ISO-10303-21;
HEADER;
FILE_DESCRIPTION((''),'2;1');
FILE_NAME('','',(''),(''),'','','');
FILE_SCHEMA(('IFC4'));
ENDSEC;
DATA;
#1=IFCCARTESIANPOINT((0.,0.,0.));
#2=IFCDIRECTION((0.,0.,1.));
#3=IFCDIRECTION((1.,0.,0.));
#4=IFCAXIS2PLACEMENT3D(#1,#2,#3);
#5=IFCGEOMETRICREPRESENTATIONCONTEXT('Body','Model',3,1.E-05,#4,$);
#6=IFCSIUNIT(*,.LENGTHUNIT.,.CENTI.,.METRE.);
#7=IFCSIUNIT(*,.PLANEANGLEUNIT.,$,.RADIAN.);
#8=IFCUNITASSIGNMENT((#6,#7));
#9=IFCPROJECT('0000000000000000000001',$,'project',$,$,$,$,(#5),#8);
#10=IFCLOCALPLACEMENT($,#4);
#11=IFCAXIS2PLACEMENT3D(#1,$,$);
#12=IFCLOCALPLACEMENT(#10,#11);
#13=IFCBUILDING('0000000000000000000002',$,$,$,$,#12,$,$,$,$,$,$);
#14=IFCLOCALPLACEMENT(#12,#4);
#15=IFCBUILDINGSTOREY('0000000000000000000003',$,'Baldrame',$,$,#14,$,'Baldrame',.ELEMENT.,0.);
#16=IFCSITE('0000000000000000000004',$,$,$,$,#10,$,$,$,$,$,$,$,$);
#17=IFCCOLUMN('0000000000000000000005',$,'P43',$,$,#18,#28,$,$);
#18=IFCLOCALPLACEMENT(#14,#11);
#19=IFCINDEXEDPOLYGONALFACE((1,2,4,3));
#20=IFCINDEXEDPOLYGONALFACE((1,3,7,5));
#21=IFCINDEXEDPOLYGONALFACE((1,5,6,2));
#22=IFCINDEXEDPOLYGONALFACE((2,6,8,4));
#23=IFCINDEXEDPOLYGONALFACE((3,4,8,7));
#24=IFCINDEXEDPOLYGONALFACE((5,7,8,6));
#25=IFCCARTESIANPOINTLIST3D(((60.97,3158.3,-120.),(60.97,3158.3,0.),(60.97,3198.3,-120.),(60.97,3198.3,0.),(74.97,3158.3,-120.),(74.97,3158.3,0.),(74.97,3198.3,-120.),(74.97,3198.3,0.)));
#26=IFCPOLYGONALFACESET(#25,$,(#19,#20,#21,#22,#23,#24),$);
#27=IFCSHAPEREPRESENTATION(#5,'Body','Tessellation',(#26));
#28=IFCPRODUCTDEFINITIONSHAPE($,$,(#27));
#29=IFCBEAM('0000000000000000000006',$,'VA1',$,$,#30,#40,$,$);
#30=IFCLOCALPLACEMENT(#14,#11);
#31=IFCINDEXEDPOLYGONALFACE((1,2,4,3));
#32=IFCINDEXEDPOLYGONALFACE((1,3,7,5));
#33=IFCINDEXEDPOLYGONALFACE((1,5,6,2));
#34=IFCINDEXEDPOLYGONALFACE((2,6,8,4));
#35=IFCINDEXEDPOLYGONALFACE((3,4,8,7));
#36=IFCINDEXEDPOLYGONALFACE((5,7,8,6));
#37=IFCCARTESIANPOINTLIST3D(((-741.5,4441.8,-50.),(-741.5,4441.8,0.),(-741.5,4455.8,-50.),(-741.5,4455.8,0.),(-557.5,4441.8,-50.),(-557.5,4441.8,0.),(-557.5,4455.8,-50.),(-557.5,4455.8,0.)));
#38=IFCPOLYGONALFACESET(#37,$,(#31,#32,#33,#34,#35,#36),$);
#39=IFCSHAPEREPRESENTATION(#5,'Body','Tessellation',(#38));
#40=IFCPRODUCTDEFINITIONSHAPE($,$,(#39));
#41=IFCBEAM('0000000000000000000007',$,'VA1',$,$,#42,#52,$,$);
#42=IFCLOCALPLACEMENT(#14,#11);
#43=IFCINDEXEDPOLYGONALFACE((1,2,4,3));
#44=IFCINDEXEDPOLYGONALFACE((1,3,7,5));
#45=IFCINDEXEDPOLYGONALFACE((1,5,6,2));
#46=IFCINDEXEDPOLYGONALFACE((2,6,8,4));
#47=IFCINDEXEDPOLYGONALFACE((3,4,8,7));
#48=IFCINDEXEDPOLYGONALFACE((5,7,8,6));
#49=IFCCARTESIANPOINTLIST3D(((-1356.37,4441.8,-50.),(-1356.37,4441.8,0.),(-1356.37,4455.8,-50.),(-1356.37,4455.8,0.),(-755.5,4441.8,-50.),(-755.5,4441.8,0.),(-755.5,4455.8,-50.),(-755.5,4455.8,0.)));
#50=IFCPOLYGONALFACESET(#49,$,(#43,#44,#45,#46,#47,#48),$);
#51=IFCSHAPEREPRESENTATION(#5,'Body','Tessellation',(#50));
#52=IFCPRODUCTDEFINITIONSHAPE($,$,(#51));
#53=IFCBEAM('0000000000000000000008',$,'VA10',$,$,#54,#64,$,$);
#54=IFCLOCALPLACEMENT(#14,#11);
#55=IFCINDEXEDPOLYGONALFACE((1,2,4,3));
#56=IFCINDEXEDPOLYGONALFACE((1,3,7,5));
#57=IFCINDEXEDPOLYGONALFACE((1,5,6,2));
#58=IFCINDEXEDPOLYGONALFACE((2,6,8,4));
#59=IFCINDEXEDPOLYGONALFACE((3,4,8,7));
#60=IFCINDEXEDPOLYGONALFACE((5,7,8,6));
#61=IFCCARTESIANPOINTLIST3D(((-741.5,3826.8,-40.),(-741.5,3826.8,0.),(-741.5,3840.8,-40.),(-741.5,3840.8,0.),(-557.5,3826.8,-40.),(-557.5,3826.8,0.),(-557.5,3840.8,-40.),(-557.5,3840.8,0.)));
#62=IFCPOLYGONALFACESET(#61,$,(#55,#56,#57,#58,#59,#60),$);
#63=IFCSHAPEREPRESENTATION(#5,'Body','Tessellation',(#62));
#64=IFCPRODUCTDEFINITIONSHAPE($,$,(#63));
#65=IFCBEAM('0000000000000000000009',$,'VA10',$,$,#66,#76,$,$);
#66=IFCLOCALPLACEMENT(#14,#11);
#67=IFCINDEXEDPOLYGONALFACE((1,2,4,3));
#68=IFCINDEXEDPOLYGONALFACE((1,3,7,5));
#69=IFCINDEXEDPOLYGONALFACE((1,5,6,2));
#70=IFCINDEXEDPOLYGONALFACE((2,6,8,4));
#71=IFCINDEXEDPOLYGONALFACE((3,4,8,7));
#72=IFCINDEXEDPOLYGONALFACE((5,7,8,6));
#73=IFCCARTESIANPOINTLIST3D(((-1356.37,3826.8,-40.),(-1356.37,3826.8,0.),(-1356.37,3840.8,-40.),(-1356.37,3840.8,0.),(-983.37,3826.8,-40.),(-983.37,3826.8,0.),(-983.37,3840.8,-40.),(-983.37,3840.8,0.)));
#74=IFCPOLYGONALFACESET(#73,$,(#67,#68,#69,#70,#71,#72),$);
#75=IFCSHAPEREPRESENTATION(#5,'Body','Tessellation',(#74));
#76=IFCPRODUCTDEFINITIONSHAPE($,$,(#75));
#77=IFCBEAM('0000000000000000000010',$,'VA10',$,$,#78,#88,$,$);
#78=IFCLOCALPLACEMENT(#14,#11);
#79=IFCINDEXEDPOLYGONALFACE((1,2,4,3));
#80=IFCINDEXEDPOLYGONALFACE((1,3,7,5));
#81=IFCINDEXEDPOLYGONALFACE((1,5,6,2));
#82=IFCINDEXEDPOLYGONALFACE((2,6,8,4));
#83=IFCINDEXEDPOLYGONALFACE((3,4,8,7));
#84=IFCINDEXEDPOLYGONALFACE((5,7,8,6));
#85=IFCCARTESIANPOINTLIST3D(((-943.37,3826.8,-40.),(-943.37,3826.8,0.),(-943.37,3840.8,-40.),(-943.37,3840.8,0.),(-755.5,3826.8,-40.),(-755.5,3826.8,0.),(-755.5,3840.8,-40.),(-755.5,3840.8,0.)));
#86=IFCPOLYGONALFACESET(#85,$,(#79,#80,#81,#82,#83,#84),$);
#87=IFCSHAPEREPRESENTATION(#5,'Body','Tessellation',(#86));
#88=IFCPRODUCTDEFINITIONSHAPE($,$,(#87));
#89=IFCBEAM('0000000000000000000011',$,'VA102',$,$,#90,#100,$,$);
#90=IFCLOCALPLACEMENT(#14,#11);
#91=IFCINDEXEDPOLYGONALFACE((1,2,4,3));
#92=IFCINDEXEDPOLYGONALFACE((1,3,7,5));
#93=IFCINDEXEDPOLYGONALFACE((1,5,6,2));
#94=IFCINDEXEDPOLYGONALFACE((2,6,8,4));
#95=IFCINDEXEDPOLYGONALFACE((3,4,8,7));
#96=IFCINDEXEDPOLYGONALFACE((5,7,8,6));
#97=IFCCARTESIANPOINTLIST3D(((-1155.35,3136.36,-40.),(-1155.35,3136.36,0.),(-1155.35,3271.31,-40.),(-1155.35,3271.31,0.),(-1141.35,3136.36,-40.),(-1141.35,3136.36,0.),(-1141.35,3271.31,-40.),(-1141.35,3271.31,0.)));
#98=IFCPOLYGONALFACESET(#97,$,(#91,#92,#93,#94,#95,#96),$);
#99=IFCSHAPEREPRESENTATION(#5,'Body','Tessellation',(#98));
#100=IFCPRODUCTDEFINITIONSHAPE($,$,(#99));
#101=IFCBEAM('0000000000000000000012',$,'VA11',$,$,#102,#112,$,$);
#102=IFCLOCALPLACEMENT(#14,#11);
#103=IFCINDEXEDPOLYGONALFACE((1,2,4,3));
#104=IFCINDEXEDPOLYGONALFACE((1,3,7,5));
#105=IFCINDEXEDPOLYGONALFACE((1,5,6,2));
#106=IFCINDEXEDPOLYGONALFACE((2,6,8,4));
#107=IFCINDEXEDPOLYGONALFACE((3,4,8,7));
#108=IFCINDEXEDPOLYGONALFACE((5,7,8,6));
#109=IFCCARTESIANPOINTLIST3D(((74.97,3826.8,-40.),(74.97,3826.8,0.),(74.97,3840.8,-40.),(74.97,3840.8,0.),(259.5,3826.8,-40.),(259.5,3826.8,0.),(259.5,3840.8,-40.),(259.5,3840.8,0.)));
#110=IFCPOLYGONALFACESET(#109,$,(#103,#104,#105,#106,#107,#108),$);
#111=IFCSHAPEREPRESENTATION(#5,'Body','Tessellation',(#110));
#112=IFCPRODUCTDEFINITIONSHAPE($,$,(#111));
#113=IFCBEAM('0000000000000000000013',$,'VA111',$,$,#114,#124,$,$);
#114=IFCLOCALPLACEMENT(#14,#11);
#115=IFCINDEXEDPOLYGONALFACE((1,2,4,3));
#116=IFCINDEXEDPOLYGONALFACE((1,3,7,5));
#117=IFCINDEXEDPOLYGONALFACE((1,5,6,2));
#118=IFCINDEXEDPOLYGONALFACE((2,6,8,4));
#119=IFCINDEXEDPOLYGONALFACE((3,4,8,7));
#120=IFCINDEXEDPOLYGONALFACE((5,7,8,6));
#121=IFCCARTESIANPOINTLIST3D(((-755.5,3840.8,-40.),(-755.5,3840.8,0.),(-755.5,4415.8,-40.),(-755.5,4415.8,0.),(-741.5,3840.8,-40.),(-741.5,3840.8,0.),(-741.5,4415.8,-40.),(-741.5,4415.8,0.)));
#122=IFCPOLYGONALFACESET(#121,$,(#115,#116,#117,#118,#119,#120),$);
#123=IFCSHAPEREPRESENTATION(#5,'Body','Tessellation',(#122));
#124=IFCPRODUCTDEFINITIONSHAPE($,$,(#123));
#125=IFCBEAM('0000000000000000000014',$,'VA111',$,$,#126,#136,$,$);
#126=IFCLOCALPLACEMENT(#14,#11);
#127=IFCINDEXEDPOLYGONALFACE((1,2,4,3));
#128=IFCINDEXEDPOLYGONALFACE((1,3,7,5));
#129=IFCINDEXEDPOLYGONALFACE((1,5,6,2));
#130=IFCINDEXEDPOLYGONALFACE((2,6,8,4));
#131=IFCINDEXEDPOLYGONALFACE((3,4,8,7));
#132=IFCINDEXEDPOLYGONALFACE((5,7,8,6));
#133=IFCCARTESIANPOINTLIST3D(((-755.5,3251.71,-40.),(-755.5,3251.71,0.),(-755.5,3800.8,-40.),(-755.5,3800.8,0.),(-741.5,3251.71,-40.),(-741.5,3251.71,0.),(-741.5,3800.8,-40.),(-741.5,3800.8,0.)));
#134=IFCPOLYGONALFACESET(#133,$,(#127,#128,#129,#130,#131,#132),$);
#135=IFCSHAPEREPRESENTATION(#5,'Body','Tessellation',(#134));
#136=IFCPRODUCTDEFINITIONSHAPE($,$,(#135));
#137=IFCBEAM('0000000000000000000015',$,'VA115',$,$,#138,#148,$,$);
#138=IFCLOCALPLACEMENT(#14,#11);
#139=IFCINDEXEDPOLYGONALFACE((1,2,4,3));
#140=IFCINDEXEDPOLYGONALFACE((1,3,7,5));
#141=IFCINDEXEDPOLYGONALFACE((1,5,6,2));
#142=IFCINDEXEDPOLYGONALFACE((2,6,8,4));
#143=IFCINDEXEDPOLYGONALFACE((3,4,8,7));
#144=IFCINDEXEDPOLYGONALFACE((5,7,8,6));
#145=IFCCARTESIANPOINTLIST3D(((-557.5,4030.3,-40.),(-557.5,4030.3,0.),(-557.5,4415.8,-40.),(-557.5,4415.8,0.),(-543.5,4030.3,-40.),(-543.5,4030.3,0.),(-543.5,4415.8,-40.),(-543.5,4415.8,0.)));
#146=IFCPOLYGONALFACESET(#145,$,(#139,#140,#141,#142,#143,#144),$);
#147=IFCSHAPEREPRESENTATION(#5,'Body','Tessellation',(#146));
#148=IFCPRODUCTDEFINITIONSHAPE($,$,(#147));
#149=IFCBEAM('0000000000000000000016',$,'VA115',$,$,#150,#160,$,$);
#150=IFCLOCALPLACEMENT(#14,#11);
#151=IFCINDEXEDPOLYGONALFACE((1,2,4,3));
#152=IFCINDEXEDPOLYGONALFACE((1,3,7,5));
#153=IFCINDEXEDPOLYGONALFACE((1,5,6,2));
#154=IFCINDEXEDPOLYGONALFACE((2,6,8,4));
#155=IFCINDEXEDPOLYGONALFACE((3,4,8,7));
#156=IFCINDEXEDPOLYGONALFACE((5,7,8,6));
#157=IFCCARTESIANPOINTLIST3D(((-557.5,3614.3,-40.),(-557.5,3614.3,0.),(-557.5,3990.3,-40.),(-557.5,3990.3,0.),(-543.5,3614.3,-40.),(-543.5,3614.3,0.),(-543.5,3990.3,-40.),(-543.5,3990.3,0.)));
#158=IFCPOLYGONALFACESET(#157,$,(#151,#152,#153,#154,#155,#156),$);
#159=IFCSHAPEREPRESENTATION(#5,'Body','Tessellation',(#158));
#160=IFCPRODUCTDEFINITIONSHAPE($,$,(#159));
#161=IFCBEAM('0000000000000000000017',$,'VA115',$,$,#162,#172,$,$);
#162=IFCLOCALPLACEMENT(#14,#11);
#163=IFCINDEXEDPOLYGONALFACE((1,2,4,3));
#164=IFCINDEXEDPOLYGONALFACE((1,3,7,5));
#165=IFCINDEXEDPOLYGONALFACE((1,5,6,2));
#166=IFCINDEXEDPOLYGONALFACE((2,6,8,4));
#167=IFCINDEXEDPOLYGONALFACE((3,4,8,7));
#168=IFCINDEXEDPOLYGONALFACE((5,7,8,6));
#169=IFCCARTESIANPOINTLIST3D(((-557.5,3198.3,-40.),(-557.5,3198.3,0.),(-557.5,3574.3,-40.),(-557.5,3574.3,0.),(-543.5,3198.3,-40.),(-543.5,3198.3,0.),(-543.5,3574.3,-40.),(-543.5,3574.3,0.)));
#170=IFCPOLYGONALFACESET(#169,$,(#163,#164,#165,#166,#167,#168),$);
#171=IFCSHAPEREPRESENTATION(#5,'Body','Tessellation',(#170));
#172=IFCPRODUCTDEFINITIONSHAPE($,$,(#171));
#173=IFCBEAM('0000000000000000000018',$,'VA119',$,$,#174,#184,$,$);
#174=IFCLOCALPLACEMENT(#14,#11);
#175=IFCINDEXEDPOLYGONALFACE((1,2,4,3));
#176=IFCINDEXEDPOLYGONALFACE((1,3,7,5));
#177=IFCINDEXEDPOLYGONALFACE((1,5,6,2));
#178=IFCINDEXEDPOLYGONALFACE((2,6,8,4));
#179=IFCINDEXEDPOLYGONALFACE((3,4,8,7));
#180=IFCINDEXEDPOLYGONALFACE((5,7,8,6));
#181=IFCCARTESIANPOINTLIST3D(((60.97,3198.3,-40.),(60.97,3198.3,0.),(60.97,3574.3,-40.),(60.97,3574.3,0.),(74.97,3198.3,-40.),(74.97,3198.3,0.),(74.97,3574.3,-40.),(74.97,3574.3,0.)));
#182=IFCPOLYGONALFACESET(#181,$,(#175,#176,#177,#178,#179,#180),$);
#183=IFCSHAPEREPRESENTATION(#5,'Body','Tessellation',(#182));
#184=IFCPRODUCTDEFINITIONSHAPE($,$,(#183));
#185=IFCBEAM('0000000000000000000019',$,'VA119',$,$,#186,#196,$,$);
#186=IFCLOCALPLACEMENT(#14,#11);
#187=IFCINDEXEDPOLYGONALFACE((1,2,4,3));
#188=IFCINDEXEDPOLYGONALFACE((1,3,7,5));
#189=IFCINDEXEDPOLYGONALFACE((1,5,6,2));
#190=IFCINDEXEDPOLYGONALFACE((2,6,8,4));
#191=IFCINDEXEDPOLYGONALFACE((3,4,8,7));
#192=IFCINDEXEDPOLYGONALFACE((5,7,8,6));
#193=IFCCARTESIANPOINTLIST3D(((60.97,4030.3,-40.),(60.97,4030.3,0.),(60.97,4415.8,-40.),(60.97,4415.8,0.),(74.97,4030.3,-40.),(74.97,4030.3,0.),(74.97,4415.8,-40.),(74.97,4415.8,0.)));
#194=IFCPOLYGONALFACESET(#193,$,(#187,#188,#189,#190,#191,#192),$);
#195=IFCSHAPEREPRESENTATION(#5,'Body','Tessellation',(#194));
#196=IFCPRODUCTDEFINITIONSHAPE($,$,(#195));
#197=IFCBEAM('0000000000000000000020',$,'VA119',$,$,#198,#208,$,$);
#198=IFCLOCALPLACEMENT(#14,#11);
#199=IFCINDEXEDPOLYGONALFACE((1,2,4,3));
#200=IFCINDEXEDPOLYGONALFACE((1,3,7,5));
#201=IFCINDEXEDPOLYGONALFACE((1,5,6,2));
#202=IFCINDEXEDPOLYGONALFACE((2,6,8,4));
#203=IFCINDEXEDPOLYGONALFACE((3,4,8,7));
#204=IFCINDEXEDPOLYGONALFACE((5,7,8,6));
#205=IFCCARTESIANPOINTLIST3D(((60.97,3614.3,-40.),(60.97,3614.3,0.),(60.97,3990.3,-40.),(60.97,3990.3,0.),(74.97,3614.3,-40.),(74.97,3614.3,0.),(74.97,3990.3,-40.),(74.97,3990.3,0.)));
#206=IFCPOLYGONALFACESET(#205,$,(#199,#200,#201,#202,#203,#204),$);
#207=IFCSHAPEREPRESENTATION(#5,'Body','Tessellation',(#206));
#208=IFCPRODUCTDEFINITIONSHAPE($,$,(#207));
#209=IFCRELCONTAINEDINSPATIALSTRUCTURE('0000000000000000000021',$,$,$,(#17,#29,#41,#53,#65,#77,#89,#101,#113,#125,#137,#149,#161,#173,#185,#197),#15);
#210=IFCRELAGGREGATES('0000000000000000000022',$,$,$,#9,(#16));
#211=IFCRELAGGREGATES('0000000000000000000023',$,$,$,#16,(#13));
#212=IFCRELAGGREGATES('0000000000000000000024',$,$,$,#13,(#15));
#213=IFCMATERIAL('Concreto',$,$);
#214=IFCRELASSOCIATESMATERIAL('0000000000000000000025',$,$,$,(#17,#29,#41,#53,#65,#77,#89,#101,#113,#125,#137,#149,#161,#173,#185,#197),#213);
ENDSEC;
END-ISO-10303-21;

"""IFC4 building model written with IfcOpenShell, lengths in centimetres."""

from ifc_helpers import new_model, si_unit, frame, origin, origin_with_axes, origin_2d_with_axis, place, context, project, spatial, rectangle, extrude, material, element, save


model = new_model("IFC4")

# Units and contexts
model_context = context("Model", 3, precision=1e-05, world=origin_with_axes(), identifier="Body")
ifc_project = project(units=[si_unit("LENGTHUNIT", "METRE", prefix="CENTI"), si_unit("PLANEANGLEUNIT", "RADIAN")], contexts=[model_context])

# Site, building, storey
site_placement = place(None, origin_with_axes())
site = spatial("IfcSite", under=ifc_project, at=site_placement)
building_placement = place(site_placement, origin())
building = spatial("IfcBuilding", under=site, at=building_placement)
storey_placement = place(building_placement, origin_with_axes())
storey = spatial("IfcBuildingStorey", under=building, at=storey_placement, Name="Baldrame", LongName="Baldrame", CompositionType="ELEMENT", Elevation=0.0)

# Shared definitions
ifc_material = material(Name="Concreto")

# Column
for number, where, z_axis, x_axis, name in (
    (1, (67.97, 3178.3, 0.0), (0.0, 0.0, 1.0), (1.0, 0.0, 0.0), "P43"),
):
    element("IfcColumn", number, at=place(storey_placement, frame(where, z_axis=z_axis, x_axis=x_axis)), inside=storey, material=ifc_material, Name=name, context=model_context, shape_type="SolidModel", body=[
        extrude(rectangle(XDim=14.0, YDim=40.0, at=origin_2d_with_axis()), frame((0.0, 0.0, -120.0), z_axis=(0.0, 0.0, 1.0), x_axis=(1.0, 0.0, 0.0)), (0.0, 0.0, 1.0), 120.0),
    ])

# Beams
beam_1_placement = place(storey_placement, frame((-649.5, 4448.8, 0.0), z_axis=(0.0, 0.0, 1.0), x_axis=(1.0, 0.0, 0.0)))
element("IfcBeam", 2, at=beam_1_placement, inside=storey, material=ifc_material, Name="VA1", context=model_context, shape_type="SolidModel", body=[
    extrude(rectangle(XDim=14.0, YDim=50.0, at=origin_2d_with_axis()), frame((-92.0, 0.0, -25.0), z_axis=(1.0, 0.0, 0.0), x_axis=(0.0, 1.0, 0.0)), (0.0, 0.0, 1.0), 184.0),
])
beam_2_placement = place(storey_placement, frame((-1055.93, 4448.8, 0.0), z_axis=(0.0, 0.0, 1.0), x_axis=(1.0, 0.0, 0.0)))
element("IfcBeam", 3, at=beam_2_placement, inside=storey, material=ifc_material, Name="VA1", context=model_context, shape_type="SolidModel", body=[
    extrude(rectangle(XDim=14.0, YDim=50.0, at=origin_2d_with_axis()), frame((-300.44, 0.0, -25.0), z_axis=(1.0, 0.0, 0.0), x_axis=(0.0, 1.0, 0.0)), (0.0, 0.0, 1.0), 600.87),
])
beam_3_placement = place(storey_placement, frame((-649.5, 3833.8, 0.0), z_axis=(0.0, 0.0, 1.0), x_axis=(1.0, 0.0, 0.0)))
element("IfcBeam", 4, at=beam_3_placement, inside=storey, material=ifc_material, Name="VA10", context=model_context, shape_type="SolidModel", body=[
    extrude(rectangle(XDim=14.0, YDim=40.0, at=origin_2d_with_axis()), frame((-92.0, 0.0, -20.0), z_axis=(1.0, 0.0, 0.0), x_axis=(0.0, 1.0, 0.0)), (0.0, 0.0, 1.0), 184.0),
])
beam_4_placement = place(storey_placement, frame((-1169.87, 3833.8, 0.0), z_axis=(0.0, 0.0, 1.0), x_axis=(1.0, 0.0, 0.0)))
element("IfcBeam", 5, at=beam_4_placement, inside=storey, material=ifc_material, Name="VA10", context=model_context, shape_type="SolidModel", body=[
    extrude(rectangle(XDim=14.0, YDim=40.0, at=origin_2d_with_axis()), frame((-186.5, 0.0, -20.0), z_axis=(1.0, 0.0, 0.0), x_axis=(0.0, 1.0, 0.0)), (0.0, 0.0, 1.0), 373.0),
])
beam_5_placement = place(storey_placement, frame((-849.43, 3833.8, 0.0), z_axis=(0.0, 0.0, 1.0), x_axis=(1.0, 0.0, 0.0)))
element("IfcBeam", 6, at=beam_5_placement, inside=storey, material=ifc_material, Name="VA10", context=model_context, shape_type="SolidModel", body=[
    extrude(rectangle(XDim=14.0, YDim=40.0, at=origin_2d_with_axis()), frame((-93.94, 0.0, -20.0), z_axis=(1.0, 0.0, 0.0), x_axis=(0.0, 1.0, 0.0)), (0.0, 0.0, 1.0), 187.87),
])
beam_6_placement = place(storey_placement, frame((-1148.35, 3203.83, 0.0), z_axis=(0.0, 0.0, 1.0), x_axis=(1.0, 0.0, 0.0)))
element("IfcBeam", 7, at=beam_6_placement, inside=storey, material=ifc_material, Name="VA102", context=model_context, shape_type="SolidModel", body=[
    extrude(rectangle(XDim=14.0, YDim=40.0, at=origin_2d_with_axis()), frame((0.0, -67.48, -20.0), z_axis=(0.0, 1.0, 0.0), x_axis=(-1.0, 0.0, 0.0)), (0.0, 0.0, 1.0), 134.95),
])
beam_7_placement = place(storey_placement, frame((167.24, 3833.8, 0.0), z_axis=(0.0, 0.0, 1.0), x_axis=(1.0, 0.0, 0.0)))
element("IfcBeam", 8, at=beam_7_placement, inside=storey, material=ifc_material, Name="VA11", context=model_context, shape_type="SolidModel", body=[
    extrude(rectangle(XDim=14.0, YDim=40.0, at=origin_2d_with_axis()), frame((-92.27, 0.0, -20.0), z_axis=(1.0, 0.0, 0.0), x_axis=(0.0, 1.0, 0.0)), (0.0, 0.0, 1.0), 184.53),
])
beam_8_placement = place(storey_placement, frame((-748.5, 4128.3, 0.0), z_axis=(0.0, 0.0, 1.0), x_axis=(1.0, 0.0, 0.0)))
element("IfcBeam", 9, at=beam_8_placement, inside=storey, material=ifc_material, Name="VA111", context=model_context, shape_type="SolidModel", body=[
    extrude(rectangle(XDim=14.0, YDim=40.0, at=origin_2d_with_axis()), frame((0.0, -287.5, -20.0), z_axis=(0.0, 1.0, 0.0), x_axis=(-1.0, 0.0, 0.0)), (0.0, 0.0, 1.0), 575.0),
])
beam_9_placement = place(storey_placement, frame((-748.5, 3526.26, 0.0), z_axis=(0.0, 0.0, 1.0), x_axis=(1.0, 0.0, 0.0)))
element("IfcBeam", 10, at=beam_9_placement, inside=storey, material=ifc_material, Name="VA111", context=model_context, shape_type="SolidModel", body=[
    extrude(rectangle(XDim=14.0, YDim=40.0, at=origin_2d_with_axis()), frame((0.0, -274.55, -20.0), z_axis=(0.0, 1.0, 0.0), x_axis=(-1.0, 0.0, 0.0)), (0.0, 0.0, 1.0), 549.09),
])
beam_10_placement = place(storey_placement, frame((-550.5, 4223.05, 0.0), z_axis=(0.0, 0.0, 1.0), x_axis=(1.0, 0.0, 0.0)))
element("IfcBeam", 11, at=beam_10_placement, inside=storey, material=ifc_material, Name="VA115", context=model_context, shape_type="SolidModel", body=[
    extrude(rectangle(XDim=14.0, YDim=40.0, at=origin_2d_with_axis()), frame((0.0, -192.75, -20.0), z_axis=(0.0, 1.0, 0.0), x_axis=(-1.0, 0.0, 0.0)), (0.0, 0.0, 1.0), 385.5),
])
for number, where, z_axis, x_axis, name in (
    (12, (-550.5, 3802.3, 0.0), (0.0, 0.0, 1.0), (1.0, 0.0, 0.0), "VA115"),
    (13, (-550.5, 3386.3, 0.0), (0.0, 0.0, 1.0), (1.0, 0.0, 0.0), "VA115"),
    (14, (67.97, 3386.3, 0.0), (0.0, 0.0, 1.0), (1.0, 0.0, 0.0), "VA119"),
):
    element("IfcBeam", number, at=place(storey_placement, frame(where, z_axis=z_axis, x_axis=x_axis)), inside=storey, material=ifc_material, Name=name, context=model_context, shape_type="SolidModel", body=[
        extrude(rectangle(XDim=14.0, YDim=40.0, at=origin_2d_with_axis()), frame((0.0, -188.0, -20.0), z_axis=(0.0, 1.0, 0.0), x_axis=(-1.0, 0.0, 0.0)), (0.0, 0.0, 1.0), 376.0),
    ])
beam_11_placement = place(storey_placement, frame((67.97, 4223.05, 0.0), z_axis=(0.0, 0.0, 1.0), x_axis=(1.0, 0.0, 0.0)))
element("IfcBeam", 15, at=beam_11_placement, inside=storey, material=ifc_material, Name="VA119", context=model_context, shape_type="SolidModel", body=[
    extrude(rectangle(XDim=14.0, YDim=40.0, at=origin_2d_with_axis()), frame((0.0, -192.75, -20.0), z_axis=(0.0, 1.0, 0.0), x_axis=(-1.0, 0.0, 0.0)), (0.0, 0.0, 1.0), 385.5),
])
beam_12_placement = place(storey_placement, frame((67.97, 3802.3, 0.0), z_axis=(0.0, 0.0, 1.0), x_axis=(1.0, 0.0, 0.0)))
element("IfcBeam", 16, at=beam_12_placement, inside=storey, material=ifc_material, Name="VA119", context=model_context, shape_type="SolidModel", body=[
    extrude(rectangle(XDim=14.0, YDim=40.0, at=origin_2d_with_axis()), frame((0.0, -188.0, -20.0), z_axis=(0.0, 1.0, 0.0), x_axis=(-1.0, 0.0, 0.0)), (0.0, 0.0, 1.0), 376.0),
])

save(model, "model.ifc")
